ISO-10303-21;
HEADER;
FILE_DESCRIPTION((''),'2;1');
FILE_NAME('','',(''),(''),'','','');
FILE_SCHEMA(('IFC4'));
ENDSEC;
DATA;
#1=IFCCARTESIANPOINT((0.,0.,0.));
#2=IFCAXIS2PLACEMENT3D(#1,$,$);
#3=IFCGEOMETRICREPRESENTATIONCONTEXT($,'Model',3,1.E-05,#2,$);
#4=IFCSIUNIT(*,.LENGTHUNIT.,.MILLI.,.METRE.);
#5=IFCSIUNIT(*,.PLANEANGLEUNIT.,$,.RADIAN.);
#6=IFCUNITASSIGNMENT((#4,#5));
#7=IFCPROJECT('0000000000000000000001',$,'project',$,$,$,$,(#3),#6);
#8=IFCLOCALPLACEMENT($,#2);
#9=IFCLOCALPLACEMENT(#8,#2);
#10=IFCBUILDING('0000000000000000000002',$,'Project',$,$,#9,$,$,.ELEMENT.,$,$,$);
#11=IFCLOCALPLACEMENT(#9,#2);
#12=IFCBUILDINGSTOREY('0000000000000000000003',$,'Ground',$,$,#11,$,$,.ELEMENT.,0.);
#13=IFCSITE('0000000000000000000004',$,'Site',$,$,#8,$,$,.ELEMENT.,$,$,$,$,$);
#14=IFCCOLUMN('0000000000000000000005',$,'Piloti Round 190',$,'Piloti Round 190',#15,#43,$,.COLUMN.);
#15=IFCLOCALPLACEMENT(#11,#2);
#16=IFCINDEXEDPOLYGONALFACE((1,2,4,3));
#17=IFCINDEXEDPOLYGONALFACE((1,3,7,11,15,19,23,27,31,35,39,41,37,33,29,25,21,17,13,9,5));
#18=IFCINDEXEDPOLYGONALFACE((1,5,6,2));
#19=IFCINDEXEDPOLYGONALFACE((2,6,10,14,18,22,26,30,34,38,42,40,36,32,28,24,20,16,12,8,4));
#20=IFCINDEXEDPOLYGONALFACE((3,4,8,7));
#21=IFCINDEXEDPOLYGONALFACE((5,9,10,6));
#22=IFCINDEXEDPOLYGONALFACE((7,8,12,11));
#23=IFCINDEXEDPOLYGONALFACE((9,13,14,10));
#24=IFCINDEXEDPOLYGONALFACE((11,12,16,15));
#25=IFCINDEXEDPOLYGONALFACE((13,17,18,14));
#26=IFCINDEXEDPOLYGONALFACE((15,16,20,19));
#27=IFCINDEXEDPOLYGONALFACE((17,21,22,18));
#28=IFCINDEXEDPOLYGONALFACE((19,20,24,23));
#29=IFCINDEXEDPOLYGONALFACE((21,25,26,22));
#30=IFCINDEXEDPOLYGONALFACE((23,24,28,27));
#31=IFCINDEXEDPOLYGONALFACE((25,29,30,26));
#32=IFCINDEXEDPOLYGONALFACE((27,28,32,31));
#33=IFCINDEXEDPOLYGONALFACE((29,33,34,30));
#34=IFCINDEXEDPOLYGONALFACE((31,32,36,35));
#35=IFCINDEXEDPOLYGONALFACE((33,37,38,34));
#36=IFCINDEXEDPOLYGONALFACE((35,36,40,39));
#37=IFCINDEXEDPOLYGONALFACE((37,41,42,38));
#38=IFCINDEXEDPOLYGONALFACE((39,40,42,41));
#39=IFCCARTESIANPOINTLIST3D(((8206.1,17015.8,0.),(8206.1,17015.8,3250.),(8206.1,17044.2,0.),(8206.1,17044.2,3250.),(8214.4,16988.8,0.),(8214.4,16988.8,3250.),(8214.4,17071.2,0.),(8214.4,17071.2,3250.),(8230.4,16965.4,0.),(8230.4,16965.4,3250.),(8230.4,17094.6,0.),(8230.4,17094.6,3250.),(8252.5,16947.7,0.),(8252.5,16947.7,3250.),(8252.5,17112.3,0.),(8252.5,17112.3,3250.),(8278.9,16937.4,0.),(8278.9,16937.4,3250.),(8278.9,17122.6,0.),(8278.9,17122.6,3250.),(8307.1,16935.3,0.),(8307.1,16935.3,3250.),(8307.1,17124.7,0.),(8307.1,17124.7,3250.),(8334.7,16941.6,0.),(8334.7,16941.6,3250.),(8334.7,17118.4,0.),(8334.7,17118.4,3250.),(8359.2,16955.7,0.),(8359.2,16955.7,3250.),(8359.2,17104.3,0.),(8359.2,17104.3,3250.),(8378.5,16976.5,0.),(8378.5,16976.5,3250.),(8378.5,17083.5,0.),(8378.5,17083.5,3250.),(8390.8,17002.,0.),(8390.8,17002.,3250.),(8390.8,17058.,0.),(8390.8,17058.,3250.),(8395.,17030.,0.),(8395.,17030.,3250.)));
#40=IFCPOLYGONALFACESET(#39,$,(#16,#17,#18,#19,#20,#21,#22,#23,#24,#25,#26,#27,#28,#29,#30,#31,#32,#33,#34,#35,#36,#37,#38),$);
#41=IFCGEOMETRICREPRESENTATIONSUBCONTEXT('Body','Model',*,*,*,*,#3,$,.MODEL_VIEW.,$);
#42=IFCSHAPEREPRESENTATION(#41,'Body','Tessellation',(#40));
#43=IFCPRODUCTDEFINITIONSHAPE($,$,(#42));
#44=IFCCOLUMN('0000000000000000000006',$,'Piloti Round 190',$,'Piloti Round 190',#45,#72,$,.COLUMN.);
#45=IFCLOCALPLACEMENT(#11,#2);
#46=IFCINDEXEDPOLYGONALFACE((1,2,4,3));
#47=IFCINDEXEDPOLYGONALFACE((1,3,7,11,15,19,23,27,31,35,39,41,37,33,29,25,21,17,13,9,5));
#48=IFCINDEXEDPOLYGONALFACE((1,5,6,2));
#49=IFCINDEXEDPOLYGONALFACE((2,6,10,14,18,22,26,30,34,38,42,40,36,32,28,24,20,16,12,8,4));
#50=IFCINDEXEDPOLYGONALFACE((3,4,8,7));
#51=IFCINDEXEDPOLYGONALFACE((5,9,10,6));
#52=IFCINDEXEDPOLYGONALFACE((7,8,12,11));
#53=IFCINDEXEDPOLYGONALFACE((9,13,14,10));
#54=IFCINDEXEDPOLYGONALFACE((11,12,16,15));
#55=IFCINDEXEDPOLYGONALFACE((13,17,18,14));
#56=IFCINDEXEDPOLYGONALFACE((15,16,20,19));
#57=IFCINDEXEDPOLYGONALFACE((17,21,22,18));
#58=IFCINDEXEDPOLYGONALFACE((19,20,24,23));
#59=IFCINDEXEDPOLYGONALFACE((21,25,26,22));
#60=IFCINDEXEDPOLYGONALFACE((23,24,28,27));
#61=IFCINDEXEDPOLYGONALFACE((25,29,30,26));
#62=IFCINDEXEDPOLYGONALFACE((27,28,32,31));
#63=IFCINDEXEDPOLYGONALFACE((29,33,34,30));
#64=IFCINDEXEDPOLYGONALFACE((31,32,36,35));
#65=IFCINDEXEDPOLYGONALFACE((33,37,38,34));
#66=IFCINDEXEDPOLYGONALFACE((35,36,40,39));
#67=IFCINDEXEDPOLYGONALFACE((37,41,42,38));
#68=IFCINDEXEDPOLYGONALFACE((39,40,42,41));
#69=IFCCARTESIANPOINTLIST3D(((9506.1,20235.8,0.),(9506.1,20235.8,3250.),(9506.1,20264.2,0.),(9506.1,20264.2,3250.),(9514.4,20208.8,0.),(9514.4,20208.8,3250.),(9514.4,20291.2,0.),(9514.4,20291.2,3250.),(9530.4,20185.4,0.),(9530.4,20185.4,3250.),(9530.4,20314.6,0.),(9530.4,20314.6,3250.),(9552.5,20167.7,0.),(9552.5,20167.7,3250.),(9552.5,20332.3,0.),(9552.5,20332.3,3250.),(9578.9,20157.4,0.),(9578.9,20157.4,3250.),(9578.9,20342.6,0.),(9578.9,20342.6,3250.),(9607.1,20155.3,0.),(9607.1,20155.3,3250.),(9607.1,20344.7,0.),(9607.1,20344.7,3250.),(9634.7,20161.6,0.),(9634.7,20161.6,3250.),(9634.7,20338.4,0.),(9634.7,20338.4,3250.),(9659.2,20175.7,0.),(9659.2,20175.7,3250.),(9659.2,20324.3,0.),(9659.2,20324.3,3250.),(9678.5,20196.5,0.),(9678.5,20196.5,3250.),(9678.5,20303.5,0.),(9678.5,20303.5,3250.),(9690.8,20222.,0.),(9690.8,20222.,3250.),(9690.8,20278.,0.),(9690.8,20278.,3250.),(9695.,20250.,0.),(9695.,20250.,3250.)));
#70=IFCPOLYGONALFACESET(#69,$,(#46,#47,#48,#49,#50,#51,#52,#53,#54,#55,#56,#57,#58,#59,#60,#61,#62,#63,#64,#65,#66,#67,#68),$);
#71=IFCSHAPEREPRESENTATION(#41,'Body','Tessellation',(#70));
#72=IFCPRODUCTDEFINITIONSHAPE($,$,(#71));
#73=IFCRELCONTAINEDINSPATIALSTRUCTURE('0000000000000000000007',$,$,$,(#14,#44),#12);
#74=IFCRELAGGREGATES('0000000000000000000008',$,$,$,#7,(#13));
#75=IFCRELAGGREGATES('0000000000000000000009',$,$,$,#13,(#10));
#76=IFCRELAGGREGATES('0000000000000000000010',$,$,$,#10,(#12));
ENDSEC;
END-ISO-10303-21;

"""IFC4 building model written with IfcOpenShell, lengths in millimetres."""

from ifc_helpers import new_model, si_unit, frame, origin, origin_2d, place, context, subcontext, project, spatial, circle, extrude, element, save


model = new_model("IFC4")

# Units and contexts
model_context = context("Model", 3, precision=1e-05, world=origin())
body_context = subcontext(model_context, "Body", "Model", "MODEL_VIEW")
ifc_project = project(units=[si_unit("LENGTHUNIT", "METRE", prefix="MILLI"), si_unit("PLANEANGLEUNIT", "RADIAN")], contexts=[model_context])

# Site, building, storey
site_placement = place(None, origin())
site = spatial("IfcSite", under=ifc_project, at=site_placement, Name="Site", CompositionType="ELEMENT")
building_placement = place(site_placement, origin())
building = spatial("IfcBuilding", under=site, at=building_placement, Name="Project", CompositionType="ELEMENT")
storey_placement = place(building_placement, origin())
storey = spatial("IfcBuildingStorey", under=building, at=storey_placement, Name="Ground", CompositionType="ELEMENT", Elevation=0.0)

# Columns
for number, where, z_axis, x_axis, name in (
    (1, (8300.0, 17030.0, 0.0), (0.0, 0.0, 1.0), (1.0, 0.0, 0.0), "Piloti Round 190"),
    (2, (9600.0, 20250.0, 0.0), (0.0, 0.0, 1.0), (1.0, 0.0, 0.0), "Piloti Round 190"),
):
    element("IfcColumn", number, at=place(storey_placement, frame(where, z_axis=z_axis, x_axis=x_axis)), inside=storey, Name=name, ObjectType="Piloti Round 190", PredefinedType="COLUMN", context=body_context, shape_type="SweptSolid", body=[
        extrude(circle(Radius=95.0, at=origin_2d()), origin(), (0.0, 0.0, 1.0), 3250.0),
    ])

save(model, "model.ifc")
